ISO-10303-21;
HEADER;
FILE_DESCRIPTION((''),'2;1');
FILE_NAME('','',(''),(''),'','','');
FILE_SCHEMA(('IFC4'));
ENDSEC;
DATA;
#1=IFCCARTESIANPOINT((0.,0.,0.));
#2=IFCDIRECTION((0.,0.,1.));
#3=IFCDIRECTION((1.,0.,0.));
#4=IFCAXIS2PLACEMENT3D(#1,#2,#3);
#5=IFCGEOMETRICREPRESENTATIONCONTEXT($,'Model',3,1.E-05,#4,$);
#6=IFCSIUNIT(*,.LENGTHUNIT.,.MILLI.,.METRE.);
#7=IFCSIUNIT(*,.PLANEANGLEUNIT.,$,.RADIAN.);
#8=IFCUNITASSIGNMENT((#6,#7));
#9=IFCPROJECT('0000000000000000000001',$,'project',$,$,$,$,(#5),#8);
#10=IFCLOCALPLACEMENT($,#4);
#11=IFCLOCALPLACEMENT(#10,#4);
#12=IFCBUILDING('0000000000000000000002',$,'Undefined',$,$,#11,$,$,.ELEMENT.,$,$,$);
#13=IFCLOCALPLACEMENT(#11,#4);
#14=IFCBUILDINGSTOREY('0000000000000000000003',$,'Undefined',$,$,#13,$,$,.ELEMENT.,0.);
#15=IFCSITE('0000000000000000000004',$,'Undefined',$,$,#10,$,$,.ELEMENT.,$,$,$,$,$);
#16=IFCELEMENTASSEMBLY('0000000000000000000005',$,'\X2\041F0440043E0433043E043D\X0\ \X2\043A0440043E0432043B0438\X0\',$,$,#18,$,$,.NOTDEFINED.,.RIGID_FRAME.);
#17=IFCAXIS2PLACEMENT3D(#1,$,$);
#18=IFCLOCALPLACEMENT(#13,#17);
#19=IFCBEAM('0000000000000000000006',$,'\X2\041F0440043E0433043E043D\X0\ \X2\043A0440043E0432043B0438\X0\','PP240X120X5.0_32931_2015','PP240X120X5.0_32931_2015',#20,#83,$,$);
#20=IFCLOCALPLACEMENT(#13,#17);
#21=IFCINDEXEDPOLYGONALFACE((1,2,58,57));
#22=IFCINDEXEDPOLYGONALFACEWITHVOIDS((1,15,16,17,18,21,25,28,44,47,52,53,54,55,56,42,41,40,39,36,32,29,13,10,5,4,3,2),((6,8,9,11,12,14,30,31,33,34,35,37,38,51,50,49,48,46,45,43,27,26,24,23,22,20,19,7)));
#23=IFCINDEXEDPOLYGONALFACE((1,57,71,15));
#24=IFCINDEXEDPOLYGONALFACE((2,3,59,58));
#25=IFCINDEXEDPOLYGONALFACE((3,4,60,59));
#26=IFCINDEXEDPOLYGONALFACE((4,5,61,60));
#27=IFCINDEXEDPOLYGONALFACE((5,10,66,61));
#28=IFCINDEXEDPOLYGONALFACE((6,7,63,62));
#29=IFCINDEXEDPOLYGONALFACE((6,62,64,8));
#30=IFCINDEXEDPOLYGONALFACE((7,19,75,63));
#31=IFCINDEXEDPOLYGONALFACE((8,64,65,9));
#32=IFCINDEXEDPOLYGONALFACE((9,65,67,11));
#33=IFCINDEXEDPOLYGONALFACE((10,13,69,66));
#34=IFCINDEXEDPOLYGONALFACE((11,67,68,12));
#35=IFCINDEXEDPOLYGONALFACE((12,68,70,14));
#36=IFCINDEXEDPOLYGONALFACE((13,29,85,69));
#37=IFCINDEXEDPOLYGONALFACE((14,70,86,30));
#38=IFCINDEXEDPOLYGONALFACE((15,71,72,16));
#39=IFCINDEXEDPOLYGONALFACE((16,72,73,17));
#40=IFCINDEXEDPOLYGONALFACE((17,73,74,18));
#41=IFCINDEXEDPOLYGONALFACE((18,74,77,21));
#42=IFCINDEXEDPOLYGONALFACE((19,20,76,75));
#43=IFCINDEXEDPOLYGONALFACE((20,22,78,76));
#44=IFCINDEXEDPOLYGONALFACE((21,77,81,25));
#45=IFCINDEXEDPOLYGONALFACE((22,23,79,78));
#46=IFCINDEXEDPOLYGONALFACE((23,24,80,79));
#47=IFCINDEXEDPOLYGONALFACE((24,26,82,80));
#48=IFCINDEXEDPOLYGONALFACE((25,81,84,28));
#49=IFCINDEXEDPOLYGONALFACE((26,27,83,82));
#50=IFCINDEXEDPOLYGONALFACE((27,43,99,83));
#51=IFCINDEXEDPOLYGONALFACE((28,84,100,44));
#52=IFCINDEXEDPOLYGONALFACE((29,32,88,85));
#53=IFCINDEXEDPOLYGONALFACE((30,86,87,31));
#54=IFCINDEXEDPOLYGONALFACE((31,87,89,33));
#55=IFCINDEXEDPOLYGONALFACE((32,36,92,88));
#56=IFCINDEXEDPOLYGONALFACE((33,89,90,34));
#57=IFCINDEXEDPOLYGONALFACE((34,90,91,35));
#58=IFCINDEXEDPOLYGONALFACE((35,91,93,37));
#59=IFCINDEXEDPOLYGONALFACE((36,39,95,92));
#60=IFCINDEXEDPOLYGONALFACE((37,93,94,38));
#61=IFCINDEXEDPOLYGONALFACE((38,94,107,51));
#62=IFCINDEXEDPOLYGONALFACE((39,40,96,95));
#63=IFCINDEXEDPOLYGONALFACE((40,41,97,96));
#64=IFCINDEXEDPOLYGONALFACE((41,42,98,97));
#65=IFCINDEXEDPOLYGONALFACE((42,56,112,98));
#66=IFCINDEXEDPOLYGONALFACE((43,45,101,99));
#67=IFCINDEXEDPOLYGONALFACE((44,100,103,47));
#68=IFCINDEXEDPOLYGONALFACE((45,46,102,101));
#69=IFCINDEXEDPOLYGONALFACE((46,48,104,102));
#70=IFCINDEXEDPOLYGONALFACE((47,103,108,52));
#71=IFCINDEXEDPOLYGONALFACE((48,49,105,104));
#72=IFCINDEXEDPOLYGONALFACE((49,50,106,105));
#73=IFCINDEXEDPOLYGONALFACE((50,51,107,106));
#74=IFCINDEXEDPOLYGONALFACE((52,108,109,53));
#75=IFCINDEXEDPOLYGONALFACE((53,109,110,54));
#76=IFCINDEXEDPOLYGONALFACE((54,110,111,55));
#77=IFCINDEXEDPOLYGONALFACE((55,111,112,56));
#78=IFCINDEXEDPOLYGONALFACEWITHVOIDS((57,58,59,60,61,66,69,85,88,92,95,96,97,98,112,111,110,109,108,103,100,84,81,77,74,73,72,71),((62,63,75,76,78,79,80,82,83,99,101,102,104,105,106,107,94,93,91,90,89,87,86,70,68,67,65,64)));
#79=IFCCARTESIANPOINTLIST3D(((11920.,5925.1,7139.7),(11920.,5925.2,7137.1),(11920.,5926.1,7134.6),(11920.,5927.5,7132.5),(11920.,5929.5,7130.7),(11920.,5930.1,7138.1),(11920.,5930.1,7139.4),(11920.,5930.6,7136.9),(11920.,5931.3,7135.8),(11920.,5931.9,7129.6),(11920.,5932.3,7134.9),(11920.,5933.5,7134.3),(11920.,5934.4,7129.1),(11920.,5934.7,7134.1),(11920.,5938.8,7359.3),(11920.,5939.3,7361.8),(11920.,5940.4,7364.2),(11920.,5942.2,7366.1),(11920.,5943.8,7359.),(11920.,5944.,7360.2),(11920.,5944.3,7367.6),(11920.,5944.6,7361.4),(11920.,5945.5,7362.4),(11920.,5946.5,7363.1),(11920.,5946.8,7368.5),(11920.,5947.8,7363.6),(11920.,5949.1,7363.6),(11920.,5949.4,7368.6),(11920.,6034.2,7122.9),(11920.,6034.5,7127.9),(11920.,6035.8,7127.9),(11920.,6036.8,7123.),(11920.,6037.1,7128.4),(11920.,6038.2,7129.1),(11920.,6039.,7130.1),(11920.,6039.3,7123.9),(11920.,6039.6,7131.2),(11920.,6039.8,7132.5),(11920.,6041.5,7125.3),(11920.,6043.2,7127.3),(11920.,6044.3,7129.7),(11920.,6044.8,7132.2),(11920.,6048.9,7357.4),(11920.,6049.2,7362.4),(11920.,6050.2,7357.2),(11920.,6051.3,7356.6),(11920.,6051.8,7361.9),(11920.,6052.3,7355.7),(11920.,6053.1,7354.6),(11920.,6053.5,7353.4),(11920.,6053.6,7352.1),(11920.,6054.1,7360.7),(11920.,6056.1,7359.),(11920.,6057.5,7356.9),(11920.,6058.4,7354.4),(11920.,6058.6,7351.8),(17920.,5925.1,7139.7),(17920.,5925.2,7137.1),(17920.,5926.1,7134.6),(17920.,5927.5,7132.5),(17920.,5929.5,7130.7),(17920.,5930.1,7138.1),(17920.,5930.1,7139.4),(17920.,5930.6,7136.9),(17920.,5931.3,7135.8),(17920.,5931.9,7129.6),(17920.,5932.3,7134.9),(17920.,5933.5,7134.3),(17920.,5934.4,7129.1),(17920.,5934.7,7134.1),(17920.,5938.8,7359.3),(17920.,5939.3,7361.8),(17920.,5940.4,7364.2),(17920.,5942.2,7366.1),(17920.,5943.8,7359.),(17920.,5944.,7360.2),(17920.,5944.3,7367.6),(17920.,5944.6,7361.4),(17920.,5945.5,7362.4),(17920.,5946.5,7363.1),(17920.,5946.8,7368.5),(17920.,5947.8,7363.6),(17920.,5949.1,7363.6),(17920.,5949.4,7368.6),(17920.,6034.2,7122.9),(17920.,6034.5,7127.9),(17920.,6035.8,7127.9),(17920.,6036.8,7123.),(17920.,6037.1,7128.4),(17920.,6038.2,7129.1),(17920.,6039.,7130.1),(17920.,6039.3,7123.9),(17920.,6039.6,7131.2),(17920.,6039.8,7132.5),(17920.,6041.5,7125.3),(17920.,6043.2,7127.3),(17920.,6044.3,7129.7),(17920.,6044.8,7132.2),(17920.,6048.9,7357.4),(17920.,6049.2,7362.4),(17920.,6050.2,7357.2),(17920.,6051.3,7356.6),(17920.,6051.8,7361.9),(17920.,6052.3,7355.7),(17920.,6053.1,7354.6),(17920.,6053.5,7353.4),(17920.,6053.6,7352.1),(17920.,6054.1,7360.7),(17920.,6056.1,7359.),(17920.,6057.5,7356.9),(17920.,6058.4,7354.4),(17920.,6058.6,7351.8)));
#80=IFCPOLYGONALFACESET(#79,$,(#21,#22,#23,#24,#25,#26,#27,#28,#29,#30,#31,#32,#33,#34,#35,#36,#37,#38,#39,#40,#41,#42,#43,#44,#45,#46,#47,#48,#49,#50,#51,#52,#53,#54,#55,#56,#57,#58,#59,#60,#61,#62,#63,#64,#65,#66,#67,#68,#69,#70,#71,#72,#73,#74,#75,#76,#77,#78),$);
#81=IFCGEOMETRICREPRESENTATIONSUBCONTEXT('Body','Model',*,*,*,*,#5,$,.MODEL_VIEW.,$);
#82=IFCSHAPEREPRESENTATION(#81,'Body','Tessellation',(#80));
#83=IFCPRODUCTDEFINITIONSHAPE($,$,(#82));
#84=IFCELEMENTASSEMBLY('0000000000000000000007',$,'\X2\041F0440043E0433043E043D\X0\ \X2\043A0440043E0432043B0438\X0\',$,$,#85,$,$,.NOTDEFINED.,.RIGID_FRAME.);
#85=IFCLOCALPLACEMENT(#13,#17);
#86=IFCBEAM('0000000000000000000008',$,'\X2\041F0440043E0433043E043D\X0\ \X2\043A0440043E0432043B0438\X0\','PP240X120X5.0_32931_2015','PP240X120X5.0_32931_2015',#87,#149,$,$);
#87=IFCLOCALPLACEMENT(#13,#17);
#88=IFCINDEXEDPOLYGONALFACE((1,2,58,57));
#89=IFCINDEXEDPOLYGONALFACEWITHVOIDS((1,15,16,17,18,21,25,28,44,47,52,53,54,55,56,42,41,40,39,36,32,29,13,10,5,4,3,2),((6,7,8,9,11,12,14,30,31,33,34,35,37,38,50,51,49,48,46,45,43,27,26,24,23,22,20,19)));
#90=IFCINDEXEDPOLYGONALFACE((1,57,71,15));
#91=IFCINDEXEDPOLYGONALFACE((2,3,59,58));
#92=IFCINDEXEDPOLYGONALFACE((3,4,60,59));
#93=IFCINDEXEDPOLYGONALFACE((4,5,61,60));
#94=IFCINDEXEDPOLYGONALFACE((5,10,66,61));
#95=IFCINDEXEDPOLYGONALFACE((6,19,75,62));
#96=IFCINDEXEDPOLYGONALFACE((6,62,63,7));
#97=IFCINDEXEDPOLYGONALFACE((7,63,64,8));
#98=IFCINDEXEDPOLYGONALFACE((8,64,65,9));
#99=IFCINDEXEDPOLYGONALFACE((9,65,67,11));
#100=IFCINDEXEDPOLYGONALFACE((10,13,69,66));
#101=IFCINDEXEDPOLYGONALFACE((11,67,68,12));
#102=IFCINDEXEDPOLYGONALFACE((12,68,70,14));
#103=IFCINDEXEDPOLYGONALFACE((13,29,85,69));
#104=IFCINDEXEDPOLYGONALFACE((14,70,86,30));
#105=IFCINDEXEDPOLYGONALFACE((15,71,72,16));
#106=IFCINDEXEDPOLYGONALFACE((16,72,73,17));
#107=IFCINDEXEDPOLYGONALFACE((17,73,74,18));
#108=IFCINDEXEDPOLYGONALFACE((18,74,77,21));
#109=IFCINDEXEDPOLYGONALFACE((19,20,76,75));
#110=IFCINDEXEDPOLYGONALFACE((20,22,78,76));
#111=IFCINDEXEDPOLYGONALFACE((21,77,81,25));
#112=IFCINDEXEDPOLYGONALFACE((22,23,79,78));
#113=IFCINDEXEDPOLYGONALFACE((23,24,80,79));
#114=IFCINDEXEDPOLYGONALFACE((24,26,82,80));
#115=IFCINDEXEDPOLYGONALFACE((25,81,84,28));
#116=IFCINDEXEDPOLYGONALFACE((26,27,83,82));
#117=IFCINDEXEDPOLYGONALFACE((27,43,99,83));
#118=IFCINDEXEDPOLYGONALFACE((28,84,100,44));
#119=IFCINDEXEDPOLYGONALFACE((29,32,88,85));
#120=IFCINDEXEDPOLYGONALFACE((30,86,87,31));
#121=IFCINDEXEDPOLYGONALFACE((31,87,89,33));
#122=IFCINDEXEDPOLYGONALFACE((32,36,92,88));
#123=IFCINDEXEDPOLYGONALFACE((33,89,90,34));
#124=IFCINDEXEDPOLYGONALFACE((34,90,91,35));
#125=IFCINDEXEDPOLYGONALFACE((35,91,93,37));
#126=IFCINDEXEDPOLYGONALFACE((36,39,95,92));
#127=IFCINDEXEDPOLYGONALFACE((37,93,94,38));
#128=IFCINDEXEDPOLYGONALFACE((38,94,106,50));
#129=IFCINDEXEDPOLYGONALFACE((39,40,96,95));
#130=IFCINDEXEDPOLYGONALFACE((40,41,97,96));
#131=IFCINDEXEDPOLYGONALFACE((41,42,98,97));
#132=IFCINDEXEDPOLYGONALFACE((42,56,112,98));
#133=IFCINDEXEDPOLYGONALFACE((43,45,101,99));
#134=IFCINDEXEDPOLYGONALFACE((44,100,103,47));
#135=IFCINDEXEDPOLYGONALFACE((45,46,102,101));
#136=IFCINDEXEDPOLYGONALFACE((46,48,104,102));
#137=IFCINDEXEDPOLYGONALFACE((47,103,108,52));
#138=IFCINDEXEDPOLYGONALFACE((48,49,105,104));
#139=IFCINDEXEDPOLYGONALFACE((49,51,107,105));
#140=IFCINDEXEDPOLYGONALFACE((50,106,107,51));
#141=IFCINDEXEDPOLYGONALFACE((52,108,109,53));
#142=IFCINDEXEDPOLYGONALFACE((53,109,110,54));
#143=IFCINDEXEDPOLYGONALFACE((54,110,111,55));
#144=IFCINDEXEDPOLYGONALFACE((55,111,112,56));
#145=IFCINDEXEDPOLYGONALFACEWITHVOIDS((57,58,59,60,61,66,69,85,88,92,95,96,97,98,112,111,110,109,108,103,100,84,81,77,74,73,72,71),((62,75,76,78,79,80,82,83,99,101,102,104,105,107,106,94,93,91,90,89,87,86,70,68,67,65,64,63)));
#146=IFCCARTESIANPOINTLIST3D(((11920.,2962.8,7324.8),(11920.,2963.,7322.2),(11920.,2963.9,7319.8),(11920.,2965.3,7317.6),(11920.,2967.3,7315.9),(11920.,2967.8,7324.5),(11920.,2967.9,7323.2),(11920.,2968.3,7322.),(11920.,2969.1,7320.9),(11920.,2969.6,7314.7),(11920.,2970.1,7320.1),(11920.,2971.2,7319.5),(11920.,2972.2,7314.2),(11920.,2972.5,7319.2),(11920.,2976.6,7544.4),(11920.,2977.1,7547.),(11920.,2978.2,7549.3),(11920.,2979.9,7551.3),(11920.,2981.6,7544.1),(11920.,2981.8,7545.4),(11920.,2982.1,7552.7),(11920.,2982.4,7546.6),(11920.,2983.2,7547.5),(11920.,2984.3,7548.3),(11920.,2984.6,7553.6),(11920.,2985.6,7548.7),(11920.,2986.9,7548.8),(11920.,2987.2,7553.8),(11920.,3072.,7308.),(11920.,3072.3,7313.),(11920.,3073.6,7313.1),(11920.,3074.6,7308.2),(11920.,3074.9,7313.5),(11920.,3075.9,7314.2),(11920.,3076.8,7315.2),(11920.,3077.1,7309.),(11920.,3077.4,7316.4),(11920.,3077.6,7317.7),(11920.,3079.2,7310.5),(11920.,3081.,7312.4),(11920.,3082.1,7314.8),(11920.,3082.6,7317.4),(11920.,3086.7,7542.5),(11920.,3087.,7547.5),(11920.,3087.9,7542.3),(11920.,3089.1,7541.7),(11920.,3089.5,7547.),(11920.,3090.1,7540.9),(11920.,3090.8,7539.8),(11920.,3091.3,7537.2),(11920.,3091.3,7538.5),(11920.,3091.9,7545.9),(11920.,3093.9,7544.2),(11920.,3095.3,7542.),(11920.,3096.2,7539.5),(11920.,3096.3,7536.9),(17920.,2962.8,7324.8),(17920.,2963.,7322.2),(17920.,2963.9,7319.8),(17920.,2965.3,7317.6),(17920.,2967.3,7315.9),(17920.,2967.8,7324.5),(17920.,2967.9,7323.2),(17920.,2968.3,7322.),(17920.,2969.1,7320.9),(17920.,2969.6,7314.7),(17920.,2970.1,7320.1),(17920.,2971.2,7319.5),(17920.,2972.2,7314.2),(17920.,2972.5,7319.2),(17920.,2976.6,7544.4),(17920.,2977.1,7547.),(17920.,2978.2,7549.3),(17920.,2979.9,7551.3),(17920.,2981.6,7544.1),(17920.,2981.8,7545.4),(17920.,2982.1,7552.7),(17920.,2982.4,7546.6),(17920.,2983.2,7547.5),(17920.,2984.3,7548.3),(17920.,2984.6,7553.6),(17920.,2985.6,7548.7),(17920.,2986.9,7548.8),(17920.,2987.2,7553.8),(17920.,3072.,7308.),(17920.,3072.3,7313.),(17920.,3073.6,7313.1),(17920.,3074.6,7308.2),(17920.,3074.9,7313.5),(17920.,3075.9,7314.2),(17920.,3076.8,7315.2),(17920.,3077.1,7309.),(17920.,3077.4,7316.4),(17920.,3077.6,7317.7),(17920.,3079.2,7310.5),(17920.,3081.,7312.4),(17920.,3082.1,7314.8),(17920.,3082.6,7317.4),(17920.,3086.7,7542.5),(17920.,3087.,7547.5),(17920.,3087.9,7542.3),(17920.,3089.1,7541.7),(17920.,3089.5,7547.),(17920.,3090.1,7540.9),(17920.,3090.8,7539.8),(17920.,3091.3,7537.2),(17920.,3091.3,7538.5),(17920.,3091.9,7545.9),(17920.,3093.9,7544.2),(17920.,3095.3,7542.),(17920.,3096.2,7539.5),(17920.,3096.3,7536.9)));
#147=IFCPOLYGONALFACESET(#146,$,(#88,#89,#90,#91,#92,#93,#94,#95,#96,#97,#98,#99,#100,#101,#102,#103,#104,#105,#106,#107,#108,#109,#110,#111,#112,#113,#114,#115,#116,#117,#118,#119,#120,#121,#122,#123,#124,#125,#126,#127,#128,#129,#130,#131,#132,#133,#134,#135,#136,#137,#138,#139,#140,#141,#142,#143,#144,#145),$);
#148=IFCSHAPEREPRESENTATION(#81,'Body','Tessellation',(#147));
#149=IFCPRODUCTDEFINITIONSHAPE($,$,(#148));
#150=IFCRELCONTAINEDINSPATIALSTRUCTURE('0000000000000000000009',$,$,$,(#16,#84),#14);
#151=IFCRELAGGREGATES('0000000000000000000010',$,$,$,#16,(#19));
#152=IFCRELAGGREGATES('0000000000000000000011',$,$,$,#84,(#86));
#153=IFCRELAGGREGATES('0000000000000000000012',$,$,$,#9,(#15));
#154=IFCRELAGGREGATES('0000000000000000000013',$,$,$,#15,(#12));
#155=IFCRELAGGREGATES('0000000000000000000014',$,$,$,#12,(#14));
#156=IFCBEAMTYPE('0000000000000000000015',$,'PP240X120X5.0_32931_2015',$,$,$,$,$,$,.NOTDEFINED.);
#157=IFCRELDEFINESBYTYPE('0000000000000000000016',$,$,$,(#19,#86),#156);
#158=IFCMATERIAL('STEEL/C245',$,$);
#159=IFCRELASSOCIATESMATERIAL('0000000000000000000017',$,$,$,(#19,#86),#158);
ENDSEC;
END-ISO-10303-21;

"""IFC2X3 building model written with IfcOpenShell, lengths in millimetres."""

from ifc_helpers import new_model, si_unit, frame, origin_with_axes, origin_2d_with_axis, place, context, subcontext, project, spatial, hollow_rectangle, extrude, material, type_object, element, aggregate, save


model = new_model("IFC2X3")

# Units and contexts
model_context = context("Model", 3, precision=1e-05, world=origin_with_axes())
body_context = subcontext(model_context, "Body", "Model", "MODEL_VIEW")
ifc_project = project(units=[si_unit("LENGTHUNIT", "METRE", prefix="MILLI"), si_unit("PLANEANGLEUNIT", "RADIAN")], contexts=[model_context])

# Site, building, storey
site_placement = place(None, origin_with_axes())
site = spatial("IfcSite", under=ifc_project, at=site_placement, Name="Undefined", CompositionType="ELEMENT")
building_placement = place(site_placement, origin_with_axes())
building = spatial("IfcBuilding", under=site, at=building_placement, Name="Undefined", CompositionType="ELEMENT")
storey_placement = place(building_placement, origin_with_axes())
storey = spatial("IfcBuildingStorey", under=building, at=storey_placement, Name="Undefined", CompositionType="ELEMENT", Elevation=0.0)

# Shared definitions
ifc_material = material(Name="STEEL/C245")

# Element assemblies, beams
assembly_1_placement = place(storey_placement, origin_with_axes())
assembly_1 = element("IfcElementAssembly", 1, at=assembly_1_placement, inside=storey, Name="Прогон кровли", AssemblyPlace="NOTDEFINED", PredefinedType="RIGID_FRAME")
beam_type_1 = type_object("IfcBeamType", Name="PP240X120X5.0_32931_2015", PredefinedType="NOTDEFINED")
beam_1_placement = place(assembly_1_placement, frame((17920.0, 5991.8, 7245.7), z_axis=(0.0, 0.062378, 0.998053), x_axis=(-1.0, 0.0, 0.0)))
beam_1 = element("IfcBeam", 2, at=beam_1_placement, type_object=beam_type_1, material=ifc_material, Name="Прогон кровли", Description="PP240X120X5.0_32931_2015", ObjectType="PP240X120X5.0_32931_2015", context=body_context, shape_type="SweptSolid", body=[
    extrude(hollow_rectangle(XDim=120.0, YDim=240.0, WallThickness=5.0, InnerFilletRadius=5.0, OuterFilletRadius=10.0, at=origin_2d_with_axis()), frame((6000.0, 0.0, 0.0), z_axis=(-1.0, 0.0, 0.0), x_axis=(0.0, -1.0, 0.0)), (0.0, 0.0, 1.0), 6000.0),
])
aggregate(assembly_1, [beam_1])
assembly_2_placement = place(storey_placement, origin_with_axes())
assembly_2 = element("IfcElementAssembly", 3, at=assembly_2_placement, inside=storey, Name="Прогон кровли", AssemblyPlace="NOTDEFINED", PredefinedType="RIGID_FRAME")
beam_2_placement = place(assembly_2_placement, frame((17920.0, 3029.6, 7430.9), z_axis=(0.0, 0.062378, 0.998053), x_axis=(-1.0, 0.0, 0.0)))
beam_2 = element("IfcBeam", 4, at=beam_2_placement, type_object=beam_type_1, material=ifc_material, Name="Прогон кровли", Description="PP240X120X5.0_32931_2015", ObjectType="PP240X120X5.0_32931_2015", context=body_context, shape_type="SweptSolid", body=[
    extrude(hollow_rectangle(XDim=120.0, YDim=240.0, WallThickness=5.0, InnerFilletRadius=5.0, OuterFilletRadius=10.0, at=origin_2d_with_axis()), frame((6000.0, 0.0, 0.0), z_axis=(-1.0, 0.0, 0.0), x_axis=(0.0, -1.0, 0.0)), (0.0, 0.0, 1.0), 6000.0),
])
aggregate(assembly_2, [beam_2])

save(model, "model.ifc")
